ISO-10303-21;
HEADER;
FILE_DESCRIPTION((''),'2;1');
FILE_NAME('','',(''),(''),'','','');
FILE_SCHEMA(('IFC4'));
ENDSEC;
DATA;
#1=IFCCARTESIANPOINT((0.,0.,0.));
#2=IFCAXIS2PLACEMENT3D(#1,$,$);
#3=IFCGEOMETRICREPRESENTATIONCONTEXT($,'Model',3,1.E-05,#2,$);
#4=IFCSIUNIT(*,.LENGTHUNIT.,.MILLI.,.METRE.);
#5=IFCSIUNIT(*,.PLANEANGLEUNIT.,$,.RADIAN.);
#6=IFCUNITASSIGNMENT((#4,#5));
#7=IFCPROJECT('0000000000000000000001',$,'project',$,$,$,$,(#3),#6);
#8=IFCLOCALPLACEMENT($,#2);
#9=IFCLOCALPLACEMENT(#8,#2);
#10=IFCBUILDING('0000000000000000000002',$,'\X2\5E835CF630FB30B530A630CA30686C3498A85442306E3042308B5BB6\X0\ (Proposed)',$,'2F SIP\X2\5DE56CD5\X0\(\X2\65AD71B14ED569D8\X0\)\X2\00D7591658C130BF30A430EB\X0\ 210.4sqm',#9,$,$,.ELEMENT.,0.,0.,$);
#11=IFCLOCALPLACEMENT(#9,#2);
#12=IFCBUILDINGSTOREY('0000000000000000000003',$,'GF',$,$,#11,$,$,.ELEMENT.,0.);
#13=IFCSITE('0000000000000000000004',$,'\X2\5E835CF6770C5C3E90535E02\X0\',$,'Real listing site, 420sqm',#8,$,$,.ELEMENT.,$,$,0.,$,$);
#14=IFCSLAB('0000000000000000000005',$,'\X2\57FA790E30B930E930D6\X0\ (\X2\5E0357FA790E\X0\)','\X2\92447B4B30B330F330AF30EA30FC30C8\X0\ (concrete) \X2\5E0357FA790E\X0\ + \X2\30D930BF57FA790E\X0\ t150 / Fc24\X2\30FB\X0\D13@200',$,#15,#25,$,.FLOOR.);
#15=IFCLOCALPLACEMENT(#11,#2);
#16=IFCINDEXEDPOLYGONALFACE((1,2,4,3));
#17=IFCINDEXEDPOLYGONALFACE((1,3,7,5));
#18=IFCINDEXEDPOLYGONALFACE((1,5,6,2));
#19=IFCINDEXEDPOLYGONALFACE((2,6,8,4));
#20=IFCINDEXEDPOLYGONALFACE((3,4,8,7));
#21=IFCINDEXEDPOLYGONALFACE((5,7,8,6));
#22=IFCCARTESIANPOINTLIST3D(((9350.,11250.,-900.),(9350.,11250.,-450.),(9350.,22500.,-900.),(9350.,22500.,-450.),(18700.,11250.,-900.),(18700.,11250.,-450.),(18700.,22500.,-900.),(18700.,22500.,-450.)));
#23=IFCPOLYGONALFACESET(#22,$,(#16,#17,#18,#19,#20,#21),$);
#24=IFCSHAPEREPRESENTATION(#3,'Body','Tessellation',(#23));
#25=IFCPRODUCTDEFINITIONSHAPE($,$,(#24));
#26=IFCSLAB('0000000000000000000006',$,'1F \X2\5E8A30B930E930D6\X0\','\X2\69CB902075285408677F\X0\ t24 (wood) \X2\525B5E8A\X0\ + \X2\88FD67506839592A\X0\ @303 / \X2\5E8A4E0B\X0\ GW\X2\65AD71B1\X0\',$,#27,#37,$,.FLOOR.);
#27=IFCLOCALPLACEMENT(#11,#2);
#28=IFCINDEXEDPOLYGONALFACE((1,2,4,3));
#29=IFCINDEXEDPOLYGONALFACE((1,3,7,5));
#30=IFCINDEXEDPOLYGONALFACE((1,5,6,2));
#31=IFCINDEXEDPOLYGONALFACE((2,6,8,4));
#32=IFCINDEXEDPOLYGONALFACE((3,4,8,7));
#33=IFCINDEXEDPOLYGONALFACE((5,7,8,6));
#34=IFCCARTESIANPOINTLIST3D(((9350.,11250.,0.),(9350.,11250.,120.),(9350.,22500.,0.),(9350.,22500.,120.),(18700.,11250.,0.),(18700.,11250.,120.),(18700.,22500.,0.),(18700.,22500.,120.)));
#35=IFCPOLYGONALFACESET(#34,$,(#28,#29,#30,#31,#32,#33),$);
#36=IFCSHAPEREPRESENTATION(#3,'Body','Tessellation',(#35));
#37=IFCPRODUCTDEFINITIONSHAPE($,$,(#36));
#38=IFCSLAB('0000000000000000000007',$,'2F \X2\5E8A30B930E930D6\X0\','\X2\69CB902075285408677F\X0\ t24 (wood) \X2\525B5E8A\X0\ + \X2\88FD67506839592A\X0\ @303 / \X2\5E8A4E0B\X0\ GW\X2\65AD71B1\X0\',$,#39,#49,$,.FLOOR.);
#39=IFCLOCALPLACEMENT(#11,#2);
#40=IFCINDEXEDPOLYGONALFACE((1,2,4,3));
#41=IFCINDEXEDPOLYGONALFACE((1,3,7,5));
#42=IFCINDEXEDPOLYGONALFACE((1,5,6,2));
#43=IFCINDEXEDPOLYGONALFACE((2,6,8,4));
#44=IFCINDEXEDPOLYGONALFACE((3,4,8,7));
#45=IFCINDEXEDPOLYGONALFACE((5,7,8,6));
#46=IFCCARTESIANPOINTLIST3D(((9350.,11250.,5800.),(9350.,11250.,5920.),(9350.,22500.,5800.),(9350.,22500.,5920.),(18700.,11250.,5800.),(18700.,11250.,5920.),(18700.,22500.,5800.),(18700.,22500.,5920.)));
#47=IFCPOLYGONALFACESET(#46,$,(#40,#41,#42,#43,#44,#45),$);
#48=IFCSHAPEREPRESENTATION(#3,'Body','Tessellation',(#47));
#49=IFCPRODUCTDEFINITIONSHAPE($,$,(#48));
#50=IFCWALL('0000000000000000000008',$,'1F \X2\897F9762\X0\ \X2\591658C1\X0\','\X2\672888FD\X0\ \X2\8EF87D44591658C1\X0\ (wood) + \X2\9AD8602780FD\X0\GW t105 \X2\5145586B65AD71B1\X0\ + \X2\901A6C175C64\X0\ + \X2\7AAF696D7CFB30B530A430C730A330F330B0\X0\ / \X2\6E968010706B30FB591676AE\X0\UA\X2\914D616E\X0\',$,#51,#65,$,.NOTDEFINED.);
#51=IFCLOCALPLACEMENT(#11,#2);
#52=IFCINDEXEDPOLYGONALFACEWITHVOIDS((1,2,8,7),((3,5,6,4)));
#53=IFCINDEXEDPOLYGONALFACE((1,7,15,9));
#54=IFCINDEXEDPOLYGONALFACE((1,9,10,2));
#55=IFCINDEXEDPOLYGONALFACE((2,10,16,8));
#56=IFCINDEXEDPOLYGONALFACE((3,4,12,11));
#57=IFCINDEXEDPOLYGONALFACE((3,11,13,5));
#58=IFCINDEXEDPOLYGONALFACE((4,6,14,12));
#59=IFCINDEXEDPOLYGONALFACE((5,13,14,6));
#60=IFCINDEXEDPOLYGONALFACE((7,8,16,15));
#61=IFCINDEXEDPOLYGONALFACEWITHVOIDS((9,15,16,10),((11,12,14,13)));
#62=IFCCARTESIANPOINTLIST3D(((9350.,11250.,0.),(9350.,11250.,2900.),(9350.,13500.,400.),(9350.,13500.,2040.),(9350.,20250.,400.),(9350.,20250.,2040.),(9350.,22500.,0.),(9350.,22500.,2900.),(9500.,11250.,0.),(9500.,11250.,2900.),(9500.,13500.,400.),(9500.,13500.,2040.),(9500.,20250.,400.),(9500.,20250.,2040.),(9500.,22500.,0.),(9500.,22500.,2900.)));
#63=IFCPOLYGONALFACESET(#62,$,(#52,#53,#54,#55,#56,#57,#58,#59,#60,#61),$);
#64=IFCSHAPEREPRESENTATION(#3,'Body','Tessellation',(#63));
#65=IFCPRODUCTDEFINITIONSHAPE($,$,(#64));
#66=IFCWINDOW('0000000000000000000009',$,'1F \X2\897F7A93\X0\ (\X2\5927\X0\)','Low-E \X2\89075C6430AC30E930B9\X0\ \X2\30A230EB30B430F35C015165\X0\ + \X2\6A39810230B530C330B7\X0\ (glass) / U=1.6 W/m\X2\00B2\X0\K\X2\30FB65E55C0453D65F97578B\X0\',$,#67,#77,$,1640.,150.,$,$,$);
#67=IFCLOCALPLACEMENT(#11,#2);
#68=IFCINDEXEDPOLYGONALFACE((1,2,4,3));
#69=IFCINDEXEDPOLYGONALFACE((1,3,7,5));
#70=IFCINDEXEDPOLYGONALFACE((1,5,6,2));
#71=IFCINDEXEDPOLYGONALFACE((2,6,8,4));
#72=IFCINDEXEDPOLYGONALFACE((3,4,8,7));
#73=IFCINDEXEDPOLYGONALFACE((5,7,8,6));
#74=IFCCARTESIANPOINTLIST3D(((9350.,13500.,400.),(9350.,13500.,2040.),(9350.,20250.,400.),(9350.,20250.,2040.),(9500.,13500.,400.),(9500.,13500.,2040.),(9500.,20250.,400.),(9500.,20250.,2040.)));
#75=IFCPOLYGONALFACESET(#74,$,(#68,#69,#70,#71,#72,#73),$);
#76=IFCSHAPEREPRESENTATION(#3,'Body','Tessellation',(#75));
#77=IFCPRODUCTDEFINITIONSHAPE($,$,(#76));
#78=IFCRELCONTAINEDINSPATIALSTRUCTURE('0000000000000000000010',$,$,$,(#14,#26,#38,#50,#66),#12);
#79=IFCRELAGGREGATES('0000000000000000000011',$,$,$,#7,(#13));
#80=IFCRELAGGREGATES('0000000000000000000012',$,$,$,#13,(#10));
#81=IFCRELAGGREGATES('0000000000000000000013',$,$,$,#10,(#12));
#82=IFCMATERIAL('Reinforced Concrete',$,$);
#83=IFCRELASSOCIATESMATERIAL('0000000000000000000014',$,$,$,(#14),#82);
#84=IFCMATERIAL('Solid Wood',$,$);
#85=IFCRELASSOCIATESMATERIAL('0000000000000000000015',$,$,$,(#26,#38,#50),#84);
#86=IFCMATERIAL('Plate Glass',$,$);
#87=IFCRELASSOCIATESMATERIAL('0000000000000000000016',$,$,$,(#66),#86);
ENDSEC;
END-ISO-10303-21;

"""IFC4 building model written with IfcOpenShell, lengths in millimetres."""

from ifc_helpers import new_model, si_unit, frame, frame_2d, origin, place, context, project, spatial, rectangle, extrude, material, element, fill, save


model = new_model("IFC4")

# Units and contexts
model_context = context("Model", 3, precision=1e-05, world=origin())
ifc_project = project(units=[si_unit("LENGTHUNIT", "METRE", prefix="MILLI"), si_unit("PLANEANGLEUNIT", "RADIAN")], contexts=[model_context])

# Site, building, storey
site_placement = place(None, origin())
site = spatial("IfcSite", under=ifc_project, at=site_placement, Name="広島県尾道市", ObjectType="Real listing site, 420sqm", CompositionType="ELEMENT", RefElevation=0.0)
building_placement = place(site_placement, origin())
building = spatial("IfcBuilding", under=site, at=building_placement, Name="広島・サウナと水風呂のある家 (Proposed)", ObjectType="2F SIP工法(断熱仕様)×外壁タイル 210.4sqm", CompositionType="ELEMENT", ElevationOfRefHeight=0.0, ElevationOfTerrain=0.0)
storey_placement = place(building_placement, origin())
storey = spatial("IfcBuildingStorey", under=building, at=storey_placement, Name="GF", CompositionType="ELEMENT", Elevation=0.0)

# Shared definitions
ifc_material_1 = material(Name="Solid Wood")

# Slabs
ifc_material_2 = material(Name="Reinforced Concrete")
slab_1_placement = place(storey_placement, frame((4675.0, 5625.0, -450.0)))
element("IfcSlab", 1, at=slab_1_placement, inside=storey, material=ifc_material_2, Name="基礎スラブ (布基礎)", Description="鉄筋コンクリート (concrete) 布基礎 + ベタ基礎 t150 / Fc24・D13@200", PredefinedType="FLOOR", context=model_context, shape_type="SweptSolid", body=[
    extrude(rectangle(XDim=9350.0, YDim=11250.0, at=frame_2d((4675.0, 5625.0))), frame((4675.0, 5625.0, -450.0)), (0.0, 0.0, 1.0), 450.0),
])
slab_2_placement = place(storey_placement, frame((4675.0, 5625.0, 0.0)))
element("IfcSlab", 2, at=slab_2_placement, inside=storey, material=ifc_material_1, Name="1F 床スラブ", Description="構造用合板 t24 (wood) 剛床 + 製材根太 @303 / 床下 GW断熱", PredefinedType="FLOOR", context=model_context, shape_type="SweptSolid", body=[
    extrude(rectangle(XDim=9350.0, YDim=11250.0, at=frame_2d((4675.0, 5625.0))), frame((4675.0, 5625.0, 0.0)), (0.0, 0.0, 1.0), 120.0),
])
slab_3_placement = place(storey_placement, frame((4675.0, 5625.0, 2900.0)))
element("IfcSlab", 3, at=slab_3_placement, inside=storey, material=ifc_material_1, Name="2F 床スラブ", Description="構造用合板 t24 (wood) 剛床 + 製材根太 @303 / 床下 GW断熱", PredefinedType="FLOOR", context=model_context, shape_type="SweptSolid", body=[
    extrude(rectangle(XDim=9350.0, YDim=11250.0, at=frame_2d((4675.0, 5625.0))), frame((4675.0, 5625.0, 2900.0)), (0.0, 0.0, 1.0), 120.0),
])

# Shared definitions
ifc_material_3 = material(Name="Plate Glass")

# Wall, opening, window
wall_1_placement = place(storey_placement, frame((4675.0, 5625.0, 0.0)))
wall_1 = element("IfcWall", 4, at=wall_1_placement, inside=storey, material=ifc_material_1, Name="1F 西面 外壁", Description="木製 軸組外壁 (wood) + 高性能GW t105 充填断熱 + 通気層 + 窯業系サイディング / 準耐火・外皮UA配慮", PredefinedType="NOTDEFINED", context=model_context, shape_type="SweptSolid", body=[
    extrude(rectangle(XDim=150.0, YDim=11250.0, at=frame_2d((75.0, 5625.0))), frame((4675.0, 5625.0, 0.0)), (0.0, 0.0, 1.0), 2900.0),
])
opening_1_placement = place(storey_placement, frame((4675.0, 6750.0, 200.0)))
opening_1 = element("IfcOpeningElement", 5, at=opening_1_placement, cuts=wall_1, PredefinedType="NOTDEFINED", context=model_context, shape_type="SweptSolid", body=[
    extrude(rectangle(XDim=150.0, YDim=6750.0, at=frame_2d((75.0, 3375.0))), frame((4675.0, 6750.0, 200.0)), (0.0, 0.0, 1.0), 1640.0),
])
window_1_placement = place(storey_placement, frame((4675.0, 6750.0, 200.0)))
window_1 = element("IfcWindow", 6, at=window_1_placement, inside=storey, material=ifc_material_3, Name="1F 西窓 (大)", Description="Low-E 複層ガラス アルゴン封入 + 樹脂サッシ (glass) / U=1.6 W/m²K・日射取得型", OverallHeight=1640.0, OverallWidth=150.0, context=model_context, shape_type="SweptSolid", body=[
    extrude(rectangle(XDim=150.0, YDim=6750.0, at=frame_2d((75.0, 3375.0))), frame((4675.0, 6750.0, 200.0)), (0.0, 0.0, 1.0), 1640.0),
])
fill(opening_1, window_1)

save(model, "model.ifc")
